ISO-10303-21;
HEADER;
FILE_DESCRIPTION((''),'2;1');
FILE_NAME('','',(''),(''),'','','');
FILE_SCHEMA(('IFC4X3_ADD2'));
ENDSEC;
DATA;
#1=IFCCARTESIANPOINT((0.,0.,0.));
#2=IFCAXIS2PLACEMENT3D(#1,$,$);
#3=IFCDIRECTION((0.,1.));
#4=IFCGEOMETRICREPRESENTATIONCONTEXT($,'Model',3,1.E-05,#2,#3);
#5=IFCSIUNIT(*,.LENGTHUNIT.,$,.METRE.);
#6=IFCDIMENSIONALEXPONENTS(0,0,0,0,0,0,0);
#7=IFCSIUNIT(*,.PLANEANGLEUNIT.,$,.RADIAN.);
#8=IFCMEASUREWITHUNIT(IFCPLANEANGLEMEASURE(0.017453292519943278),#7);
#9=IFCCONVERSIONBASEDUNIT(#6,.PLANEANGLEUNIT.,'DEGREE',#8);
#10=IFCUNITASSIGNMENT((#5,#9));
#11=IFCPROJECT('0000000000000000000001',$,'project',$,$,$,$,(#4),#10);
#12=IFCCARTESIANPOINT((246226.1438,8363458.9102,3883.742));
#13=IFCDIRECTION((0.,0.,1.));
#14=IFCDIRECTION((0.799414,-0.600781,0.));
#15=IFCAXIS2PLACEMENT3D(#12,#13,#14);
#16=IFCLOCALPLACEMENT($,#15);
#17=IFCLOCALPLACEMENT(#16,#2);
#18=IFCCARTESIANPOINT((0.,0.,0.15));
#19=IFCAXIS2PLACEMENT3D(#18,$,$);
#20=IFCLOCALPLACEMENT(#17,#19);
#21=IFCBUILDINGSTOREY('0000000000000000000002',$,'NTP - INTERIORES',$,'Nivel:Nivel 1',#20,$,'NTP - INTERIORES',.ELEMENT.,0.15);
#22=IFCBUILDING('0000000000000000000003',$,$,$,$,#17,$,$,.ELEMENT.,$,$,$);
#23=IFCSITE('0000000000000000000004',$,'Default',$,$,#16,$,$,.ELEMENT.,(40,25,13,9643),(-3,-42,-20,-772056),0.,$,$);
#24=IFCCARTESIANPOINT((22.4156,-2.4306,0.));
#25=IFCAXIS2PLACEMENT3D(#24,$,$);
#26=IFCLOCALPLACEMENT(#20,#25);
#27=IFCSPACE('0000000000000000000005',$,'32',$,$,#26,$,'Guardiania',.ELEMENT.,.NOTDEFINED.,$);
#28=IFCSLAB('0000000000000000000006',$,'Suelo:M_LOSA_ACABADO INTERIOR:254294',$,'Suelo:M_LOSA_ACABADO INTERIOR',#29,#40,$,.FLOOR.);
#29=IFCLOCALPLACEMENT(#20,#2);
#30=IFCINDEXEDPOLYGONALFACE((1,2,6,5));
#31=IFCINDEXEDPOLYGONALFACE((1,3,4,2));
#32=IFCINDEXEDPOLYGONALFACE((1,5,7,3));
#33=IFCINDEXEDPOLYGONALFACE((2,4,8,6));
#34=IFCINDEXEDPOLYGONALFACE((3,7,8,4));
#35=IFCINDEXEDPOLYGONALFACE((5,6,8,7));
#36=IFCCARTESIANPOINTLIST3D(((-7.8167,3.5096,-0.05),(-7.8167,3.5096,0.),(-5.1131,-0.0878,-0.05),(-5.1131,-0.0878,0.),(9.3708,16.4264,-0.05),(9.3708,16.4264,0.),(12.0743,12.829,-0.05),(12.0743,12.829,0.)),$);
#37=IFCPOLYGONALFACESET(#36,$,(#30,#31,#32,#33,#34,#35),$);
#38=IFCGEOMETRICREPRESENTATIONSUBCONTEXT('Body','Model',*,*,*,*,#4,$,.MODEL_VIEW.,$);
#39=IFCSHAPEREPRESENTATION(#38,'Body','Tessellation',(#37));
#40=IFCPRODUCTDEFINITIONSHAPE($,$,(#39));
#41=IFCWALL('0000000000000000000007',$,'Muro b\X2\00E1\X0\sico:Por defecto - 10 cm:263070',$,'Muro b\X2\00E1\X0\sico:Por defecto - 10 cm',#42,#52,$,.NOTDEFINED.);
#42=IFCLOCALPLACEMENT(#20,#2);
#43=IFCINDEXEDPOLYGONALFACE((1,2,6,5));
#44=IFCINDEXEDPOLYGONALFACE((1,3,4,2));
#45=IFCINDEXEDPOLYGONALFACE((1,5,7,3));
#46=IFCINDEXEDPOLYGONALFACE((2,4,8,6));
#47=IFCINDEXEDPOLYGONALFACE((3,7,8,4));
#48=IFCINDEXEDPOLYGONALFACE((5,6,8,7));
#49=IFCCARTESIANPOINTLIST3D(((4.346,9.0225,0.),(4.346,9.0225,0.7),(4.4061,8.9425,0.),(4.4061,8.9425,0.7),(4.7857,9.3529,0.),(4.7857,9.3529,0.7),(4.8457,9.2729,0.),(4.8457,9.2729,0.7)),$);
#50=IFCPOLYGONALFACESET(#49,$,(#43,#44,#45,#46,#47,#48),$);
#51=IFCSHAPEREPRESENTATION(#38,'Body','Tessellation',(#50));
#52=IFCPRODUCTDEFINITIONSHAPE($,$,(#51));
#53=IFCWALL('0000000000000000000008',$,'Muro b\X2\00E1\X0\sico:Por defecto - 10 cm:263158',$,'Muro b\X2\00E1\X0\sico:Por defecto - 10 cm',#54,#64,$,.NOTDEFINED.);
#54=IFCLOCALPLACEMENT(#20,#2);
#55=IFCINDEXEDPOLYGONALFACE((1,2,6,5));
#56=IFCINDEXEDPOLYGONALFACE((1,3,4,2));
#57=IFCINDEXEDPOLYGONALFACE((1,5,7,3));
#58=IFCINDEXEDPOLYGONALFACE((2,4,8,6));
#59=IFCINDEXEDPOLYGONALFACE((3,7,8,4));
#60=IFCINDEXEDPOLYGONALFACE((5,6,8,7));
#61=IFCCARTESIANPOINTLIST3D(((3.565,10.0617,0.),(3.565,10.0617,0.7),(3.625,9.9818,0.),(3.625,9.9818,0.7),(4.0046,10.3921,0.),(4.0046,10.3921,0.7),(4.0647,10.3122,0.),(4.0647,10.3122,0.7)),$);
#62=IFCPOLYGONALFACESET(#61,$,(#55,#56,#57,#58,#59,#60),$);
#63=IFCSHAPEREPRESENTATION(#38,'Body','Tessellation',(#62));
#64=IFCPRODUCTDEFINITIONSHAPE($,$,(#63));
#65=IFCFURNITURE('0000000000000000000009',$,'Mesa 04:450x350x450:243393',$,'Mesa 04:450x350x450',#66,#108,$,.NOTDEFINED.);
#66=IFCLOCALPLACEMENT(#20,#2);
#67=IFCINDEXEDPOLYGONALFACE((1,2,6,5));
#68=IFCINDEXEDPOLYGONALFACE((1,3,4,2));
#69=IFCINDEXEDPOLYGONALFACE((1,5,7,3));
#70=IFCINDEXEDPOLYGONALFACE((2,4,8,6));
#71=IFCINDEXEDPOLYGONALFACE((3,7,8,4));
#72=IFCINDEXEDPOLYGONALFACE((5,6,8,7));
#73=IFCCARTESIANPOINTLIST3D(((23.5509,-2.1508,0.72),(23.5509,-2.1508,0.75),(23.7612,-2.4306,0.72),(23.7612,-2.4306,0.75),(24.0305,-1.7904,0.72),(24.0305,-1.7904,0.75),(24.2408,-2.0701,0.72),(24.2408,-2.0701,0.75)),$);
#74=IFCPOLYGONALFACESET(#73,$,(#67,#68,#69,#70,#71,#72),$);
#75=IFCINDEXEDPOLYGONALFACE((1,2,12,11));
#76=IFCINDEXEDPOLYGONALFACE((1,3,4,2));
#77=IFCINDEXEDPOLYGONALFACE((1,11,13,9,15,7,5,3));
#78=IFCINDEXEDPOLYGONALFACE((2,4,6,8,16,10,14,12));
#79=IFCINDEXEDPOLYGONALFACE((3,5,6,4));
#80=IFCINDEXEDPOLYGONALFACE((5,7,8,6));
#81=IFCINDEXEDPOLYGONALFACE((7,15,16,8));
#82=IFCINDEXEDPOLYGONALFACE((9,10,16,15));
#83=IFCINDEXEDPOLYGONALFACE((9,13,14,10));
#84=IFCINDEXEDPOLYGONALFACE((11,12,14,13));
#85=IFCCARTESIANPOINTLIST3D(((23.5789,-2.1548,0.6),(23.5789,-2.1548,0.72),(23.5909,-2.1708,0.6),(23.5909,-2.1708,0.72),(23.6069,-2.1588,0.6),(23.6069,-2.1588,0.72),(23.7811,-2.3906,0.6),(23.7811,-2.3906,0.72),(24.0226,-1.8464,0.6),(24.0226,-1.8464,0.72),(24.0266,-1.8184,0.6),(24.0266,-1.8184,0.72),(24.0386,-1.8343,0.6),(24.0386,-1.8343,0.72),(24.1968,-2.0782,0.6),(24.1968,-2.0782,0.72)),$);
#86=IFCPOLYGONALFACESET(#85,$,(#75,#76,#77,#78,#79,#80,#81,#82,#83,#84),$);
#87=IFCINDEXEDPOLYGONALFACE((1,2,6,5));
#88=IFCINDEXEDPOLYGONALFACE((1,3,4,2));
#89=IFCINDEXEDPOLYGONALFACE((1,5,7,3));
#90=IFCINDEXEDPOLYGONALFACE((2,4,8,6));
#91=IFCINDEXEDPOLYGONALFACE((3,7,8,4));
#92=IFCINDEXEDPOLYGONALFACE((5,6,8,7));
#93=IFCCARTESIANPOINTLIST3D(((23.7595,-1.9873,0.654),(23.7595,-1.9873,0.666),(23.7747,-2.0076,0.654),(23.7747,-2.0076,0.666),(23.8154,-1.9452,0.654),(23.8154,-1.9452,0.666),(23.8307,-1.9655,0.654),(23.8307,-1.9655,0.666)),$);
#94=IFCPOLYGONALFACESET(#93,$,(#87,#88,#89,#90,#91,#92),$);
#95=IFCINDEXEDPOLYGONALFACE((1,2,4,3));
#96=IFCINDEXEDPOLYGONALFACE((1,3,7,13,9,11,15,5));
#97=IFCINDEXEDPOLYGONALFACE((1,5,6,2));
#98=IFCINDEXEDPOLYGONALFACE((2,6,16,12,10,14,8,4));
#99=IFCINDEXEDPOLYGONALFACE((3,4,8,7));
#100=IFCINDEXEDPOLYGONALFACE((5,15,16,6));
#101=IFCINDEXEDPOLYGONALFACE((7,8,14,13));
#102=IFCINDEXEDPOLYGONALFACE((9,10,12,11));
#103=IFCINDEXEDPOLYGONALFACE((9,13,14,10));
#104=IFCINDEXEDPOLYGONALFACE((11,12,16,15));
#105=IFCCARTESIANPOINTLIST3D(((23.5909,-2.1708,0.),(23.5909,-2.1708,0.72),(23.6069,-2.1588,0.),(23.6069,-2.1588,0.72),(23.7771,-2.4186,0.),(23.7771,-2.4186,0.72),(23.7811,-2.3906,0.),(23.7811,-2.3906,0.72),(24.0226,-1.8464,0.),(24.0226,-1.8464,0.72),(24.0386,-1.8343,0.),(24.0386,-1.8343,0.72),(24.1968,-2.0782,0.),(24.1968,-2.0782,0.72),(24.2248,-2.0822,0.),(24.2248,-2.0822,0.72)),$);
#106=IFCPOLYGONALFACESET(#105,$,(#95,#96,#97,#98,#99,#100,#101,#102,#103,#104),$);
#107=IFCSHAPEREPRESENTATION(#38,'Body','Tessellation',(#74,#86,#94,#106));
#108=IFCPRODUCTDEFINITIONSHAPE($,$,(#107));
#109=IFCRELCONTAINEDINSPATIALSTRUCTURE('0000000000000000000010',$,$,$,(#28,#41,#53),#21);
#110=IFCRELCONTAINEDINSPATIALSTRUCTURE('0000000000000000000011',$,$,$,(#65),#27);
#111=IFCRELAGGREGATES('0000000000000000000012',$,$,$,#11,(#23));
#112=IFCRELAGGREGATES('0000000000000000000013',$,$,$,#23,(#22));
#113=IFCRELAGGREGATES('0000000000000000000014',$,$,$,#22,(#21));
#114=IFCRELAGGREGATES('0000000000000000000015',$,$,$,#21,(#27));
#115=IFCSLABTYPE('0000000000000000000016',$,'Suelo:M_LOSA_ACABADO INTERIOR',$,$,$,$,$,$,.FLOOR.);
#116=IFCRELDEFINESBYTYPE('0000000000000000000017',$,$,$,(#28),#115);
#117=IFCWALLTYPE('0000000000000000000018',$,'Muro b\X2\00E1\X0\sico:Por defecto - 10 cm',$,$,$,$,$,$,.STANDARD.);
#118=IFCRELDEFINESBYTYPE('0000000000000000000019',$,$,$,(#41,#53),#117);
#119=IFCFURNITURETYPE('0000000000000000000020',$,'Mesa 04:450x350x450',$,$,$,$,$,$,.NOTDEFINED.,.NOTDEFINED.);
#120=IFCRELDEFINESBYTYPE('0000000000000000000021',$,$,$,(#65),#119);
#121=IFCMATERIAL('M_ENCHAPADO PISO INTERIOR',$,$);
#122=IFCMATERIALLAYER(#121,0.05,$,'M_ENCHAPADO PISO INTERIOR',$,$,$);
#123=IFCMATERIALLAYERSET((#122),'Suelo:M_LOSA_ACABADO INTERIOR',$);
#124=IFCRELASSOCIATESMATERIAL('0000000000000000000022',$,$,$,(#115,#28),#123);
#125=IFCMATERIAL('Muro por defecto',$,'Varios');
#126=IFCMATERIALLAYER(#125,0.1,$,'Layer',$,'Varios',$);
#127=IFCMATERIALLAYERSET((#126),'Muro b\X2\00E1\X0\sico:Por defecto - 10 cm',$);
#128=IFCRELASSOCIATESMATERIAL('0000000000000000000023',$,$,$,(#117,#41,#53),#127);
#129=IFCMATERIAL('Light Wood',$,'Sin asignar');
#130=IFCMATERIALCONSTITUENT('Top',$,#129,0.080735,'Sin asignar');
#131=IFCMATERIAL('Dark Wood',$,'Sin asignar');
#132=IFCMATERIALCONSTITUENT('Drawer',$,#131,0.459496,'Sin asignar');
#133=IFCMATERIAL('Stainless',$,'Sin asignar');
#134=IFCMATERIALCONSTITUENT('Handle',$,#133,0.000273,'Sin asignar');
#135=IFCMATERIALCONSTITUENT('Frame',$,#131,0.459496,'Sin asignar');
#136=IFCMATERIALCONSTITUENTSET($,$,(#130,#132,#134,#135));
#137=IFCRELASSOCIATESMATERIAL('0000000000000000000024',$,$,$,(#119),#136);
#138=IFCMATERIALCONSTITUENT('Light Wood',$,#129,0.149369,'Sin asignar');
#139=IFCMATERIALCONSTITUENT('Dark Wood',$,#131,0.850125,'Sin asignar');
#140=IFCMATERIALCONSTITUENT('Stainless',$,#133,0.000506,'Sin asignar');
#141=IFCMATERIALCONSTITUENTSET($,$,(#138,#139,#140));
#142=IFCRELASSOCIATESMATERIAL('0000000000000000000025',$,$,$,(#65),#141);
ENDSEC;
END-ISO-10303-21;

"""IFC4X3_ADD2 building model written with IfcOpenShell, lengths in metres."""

from ifc_helpers import new_model, entity, si_unit, converted_unit, direction, frame, frame_2d, origin, origin_2d_with_axis, place, context, subcontext, project, spatial, polyline, rectangle, outline, extrude, source, transform, mapped, material, layer, layer_set, layer_usage, constituent, constituent_set, type_object, type_shapes, element, save


model = new_model("IFC4X3_ADD2")

# Units and contexts
model_context = context("Model", 3, precision=1e-05, world=origin(), true_north=direction((0.0, 1.0)))
body_context = subcontext(model_context, "Body", "Model", "MODEL_VIEW")
ifc_project = project(units=[si_unit("LENGTHUNIT", "METRE"), converted_unit("PLANEANGLEUNIT", "DEGREE", entity("IfcPlaneAngleMeasure", 0.017453292519943278), si_unit("PLANEANGLEUNIT", "RADIAN"), dimensions=[0, 0, 0, 0, 0, 0, 0])], contexts=[model_context])

# Site, building, storey
site_placement = place(None, frame((246226.1438, 8363458.9102, 3883.742), z_axis=(0.0, 0.0, 1.0), x_axis=(0.799414, -0.600781, 0.0)))
site = spatial("IfcSite", under=ifc_project, at=site_placement, Name="Default", CompositionType="ELEMENT", RefLatitude=(40, 25, 13, 9643), RefLongitude=(-3, -42, -20, -772056), RefElevation=0.0)
building_placement = place(site_placement, origin())
building = spatial("IfcBuilding", under=site, at=building_placement, CompositionType="ELEMENT")
storey_placement = place(building_placement, frame((0.0, 0.0, 0.15)))
storey = spatial("IfcBuildingStorey", under=building, at=storey_placement, Name="NTP - INTERIORES", ObjectType="Nivel:Nivel 1", LongName="NTP - INTERIORES", CompositionType="ELEMENT", Elevation=0.15)

# Slab
ifc_material_1 = material(Name="M_ENCHAPADO PISO INTERIOR")
ifc_layer_1 = layer(ifc_material_1, 0.05, Name="M_ENCHAPADO PISO INTERIOR")
ifc_layer_set_1 = layer_set([ifc_layer_1], Name="Suelo:M_LOSA_ACABADO INTERIOR")
ifc_layer_usage_1 = layer_usage(ifc_layer_set_1, "AXIS3", "POSITIVE", 0.0)
slab_type = type_object("IfcSlabType", Name="Suelo:M_LOSA_ACABADO INTERIOR", PredefinedType="FLOOR", material=ifc_layer_set_1)
slab_1_placement = place(storey_placement, origin())
element("IfcSlab", 1, at=slab_1_placement, inside=storey, type_object=slab_type, material=ifc_layer_usage_1, Name="Suelo:M_LOSA_ACABADO INTERIOR:254294", ObjectType="Suelo:M_LOSA_ACABADO INTERIOR", PredefinedType="FLOOR", context=body_context, shape_type="SweptSolid", body=[
    extrude(rectangle(XDim=4.5, YDim=21.5, at=frame_2d((0.0, 0.0), x_axis=(1.0, 0.0))), frame((2.1288, 8.1693, 0.0), z_axis=(0.0, 0.0, -1.0), x_axis=(0.60078, -0.799414, 0.0)), (0.0, 0.0, 1.0), 0.05),
])

# Walls
ifc_material_2 = material(Name="Muro por defecto", Category="Varios")
ifc_layer_2 = layer(ifc_material_2, 0.1, Name="Layer", Category="Varios")
ifc_layer_set_2 = layer_set([ifc_layer_2], Name="Muro básico:Por defecto - 10 cm")
wall_type = type_object("IfcWallType", Name="Muro básico:Por defecto - 10 cm", PredefinedType="STANDARD", material=ifc_layer_set_2)
wall_1_placement = place(storey_placement, frame((4.376, 8.9825, 0.0), z_axis=(0.0, 0.0, 1.0), x_axis=(0.799414, 0.60078, 0.0)))
element("IfcWall", 2, at=wall_1_placement, inside=storey, type_object=wall_type, material=ifc_layer_set_2, Name="Muro básico:Por defecto - 10 cm:263070", ObjectType="Muro básico:Por defecto - 10 cm", PredefinedType="NOTDEFINED", context=body_context, shape_type="SweptSolid", body=[
    extrude(rectangle(XDim=0.55, YDim=0.1, at=frame_2d((0.275, 0.0), x_axis=(-1.0, 0.0))), origin(), (0.0, 0.0, 1.0), 0.7),
])
wall_2_placement = place(storey_placement, frame((3.595, 10.0217, 0.0), z_axis=(0.0, 0.0, 1.0), x_axis=(0.799414, 0.60078, 0.0)))
element("IfcWall", 3, at=wall_2_placement, inside=storey, type_object=wall_type, material=ifc_layer_set_2, Name="Muro básico:Por defecto - 10 cm:263158", ObjectType="Muro básico:Por defecto - 10 cm", PredefinedType="NOTDEFINED", context=body_context, shape_type="SweptSolid", body=[
    extrude(rectangle(XDim=0.55, YDim=0.1, at=frame_2d((0.275, 0.0), x_axis=(-1.0, 0.0))), origin(), (0.0, 0.0, 1.0), 0.7),
])

# Shared definitions
space_placement = place(storey_placement, frame((22.4156, -2.4306, 0.0)))
space = spatial("IfcSpace", under=storey, at=space_placement, Name="32", LongName="Guardiania", CompositionType="ELEMENT", PredefinedType="NOTDEFINED")

# Furniture
ifc_material_3 = material(Name="Light Wood", Category="Sin asignar")
ifc_constituent_1 = constituent(ifc_material_3, Name="Light Wood", Category="Sin asignar", fraction=0.149369)
ifc_material_4 = material(Name="Dark Wood", Category="Sin asignar")
ifc_constituent_2 = constituent(ifc_material_4, Name="Dark Wood", Category="Sin asignar", fraction=0.850125)
ifc_material_5 = material(Name="Stainless", Category="Sin asignar")
ifc_constituent_3 = constituent(ifc_material_5, Name="Stainless", Category="Sin asignar", fraction=0.000506)
ifc_constituent_set_1 = constituent_set(constituents=[ifc_constituent_1, ifc_constituent_2, ifc_constituent_3])
ifc_constituent_4 = constituent(ifc_material_3, Name="Top", Category="Sin asignar", fraction=0.080735)
ifc_constituent_5 = constituent(ifc_material_4, Name="Drawer", Category="Sin asignar", fraction=0.459496)
ifc_constituent_6 = constituent(ifc_material_5, Name="Handle", Category="Sin asignar", fraction=0.000273)
ifc_constituent_7 = constituent(ifc_material_4, Name="Frame", Category="Sin asignar", fraction=0.459496)
ifc_constituent_set_2 = constituent_set(constituents=[ifc_constituent_4, ifc_constituent_5, ifc_constituent_6, ifc_constituent_7])
furniture_type_1 = type_object("IfcFurnitureType", Name="Mesa 04:450x350x450", AssemblyPlace="NOTDEFINED", PredefinedType="NOTDEFINED", material=ifc_constituent_set_2)
shared_shape_1 = source(origin(), body_context, "Body", "SweptSolid", [
    extrude(rectangle(XDim=0.35, YDim=0.6, at=origin_2d_with_axis()), frame((0.0, -0.0736, 0.72), z_axis=(0.0, 0.0, 1.0), x_axis=(0.0, -1.0, 0.0)), (0.0, 0.0, 1.0), 0.03),
    extrude(outline(polyline([(0.0675, -0.28), (0.0875, -0.28), (0.0875, 0.28), (0.0675, 0.28), (0.0675, 0.26), (-0.2225, 0.26), (-0.2225, -0.26), (0.0675, -0.26), (0.0675, -0.28)])), frame((0.0, -0.1411, 0.6), z_axis=(0.0, 0.0, 1.0), x_axis=(0.0, -1.0, 0.0)), (0.0, 0.0, 1.0), 0.12),
    extrude(rectangle(XDim=0.0254, YDim=0.07, at=frame_2d((0.0, 0.0), x_axis=(1.0, 0.0))), frame((0.0, -0.2413, 0.654), z_axis=(0.0, 0.0, 1.0), x_axis=(0.0, 1.0, 0.0)), (0.0, 0.0, 1.0), 0.012),
    extrude(outline(polyline([(-0.28, -0.15), (-0.26, -0.15), (-0.26, 0.14), (0.26, 0.14), (0.26, -0.15), (0.28, -0.15), (0.28, 0.16), (-0.28, 0.16), (-0.28, -0.15)])), frame((0.0, -0.0586, 0.0)), (0.0, 0.0, 1.0), 0.72),
])
type_shapes(furniture_type_1, [shared_shape_1])
furniture_1_placement = place(space_placement, frame((1.5245, 0.2613, 0.0), z_axis=(0.0, 0.0, 1.0), x_axis=(-0.799414, -0.60078, 0.0)))
element("IfcFurniture", 4, at=furniture_1_placement, inside=space, type_object=furniture_type_1, material=ifc_constituent_set_1, Name="Mesa 04:450x350x450:243393", ObjectType="Mesa 04:450x350x450", PredefinedType="NOTDEFINED", context=body_context, shape_type="MappedRepresentation", body=[
    mapped(shared_shape_1, transform((0.0, 0.0, 0.0), scale=1.0)),
])

save(model, "model.ifc")
